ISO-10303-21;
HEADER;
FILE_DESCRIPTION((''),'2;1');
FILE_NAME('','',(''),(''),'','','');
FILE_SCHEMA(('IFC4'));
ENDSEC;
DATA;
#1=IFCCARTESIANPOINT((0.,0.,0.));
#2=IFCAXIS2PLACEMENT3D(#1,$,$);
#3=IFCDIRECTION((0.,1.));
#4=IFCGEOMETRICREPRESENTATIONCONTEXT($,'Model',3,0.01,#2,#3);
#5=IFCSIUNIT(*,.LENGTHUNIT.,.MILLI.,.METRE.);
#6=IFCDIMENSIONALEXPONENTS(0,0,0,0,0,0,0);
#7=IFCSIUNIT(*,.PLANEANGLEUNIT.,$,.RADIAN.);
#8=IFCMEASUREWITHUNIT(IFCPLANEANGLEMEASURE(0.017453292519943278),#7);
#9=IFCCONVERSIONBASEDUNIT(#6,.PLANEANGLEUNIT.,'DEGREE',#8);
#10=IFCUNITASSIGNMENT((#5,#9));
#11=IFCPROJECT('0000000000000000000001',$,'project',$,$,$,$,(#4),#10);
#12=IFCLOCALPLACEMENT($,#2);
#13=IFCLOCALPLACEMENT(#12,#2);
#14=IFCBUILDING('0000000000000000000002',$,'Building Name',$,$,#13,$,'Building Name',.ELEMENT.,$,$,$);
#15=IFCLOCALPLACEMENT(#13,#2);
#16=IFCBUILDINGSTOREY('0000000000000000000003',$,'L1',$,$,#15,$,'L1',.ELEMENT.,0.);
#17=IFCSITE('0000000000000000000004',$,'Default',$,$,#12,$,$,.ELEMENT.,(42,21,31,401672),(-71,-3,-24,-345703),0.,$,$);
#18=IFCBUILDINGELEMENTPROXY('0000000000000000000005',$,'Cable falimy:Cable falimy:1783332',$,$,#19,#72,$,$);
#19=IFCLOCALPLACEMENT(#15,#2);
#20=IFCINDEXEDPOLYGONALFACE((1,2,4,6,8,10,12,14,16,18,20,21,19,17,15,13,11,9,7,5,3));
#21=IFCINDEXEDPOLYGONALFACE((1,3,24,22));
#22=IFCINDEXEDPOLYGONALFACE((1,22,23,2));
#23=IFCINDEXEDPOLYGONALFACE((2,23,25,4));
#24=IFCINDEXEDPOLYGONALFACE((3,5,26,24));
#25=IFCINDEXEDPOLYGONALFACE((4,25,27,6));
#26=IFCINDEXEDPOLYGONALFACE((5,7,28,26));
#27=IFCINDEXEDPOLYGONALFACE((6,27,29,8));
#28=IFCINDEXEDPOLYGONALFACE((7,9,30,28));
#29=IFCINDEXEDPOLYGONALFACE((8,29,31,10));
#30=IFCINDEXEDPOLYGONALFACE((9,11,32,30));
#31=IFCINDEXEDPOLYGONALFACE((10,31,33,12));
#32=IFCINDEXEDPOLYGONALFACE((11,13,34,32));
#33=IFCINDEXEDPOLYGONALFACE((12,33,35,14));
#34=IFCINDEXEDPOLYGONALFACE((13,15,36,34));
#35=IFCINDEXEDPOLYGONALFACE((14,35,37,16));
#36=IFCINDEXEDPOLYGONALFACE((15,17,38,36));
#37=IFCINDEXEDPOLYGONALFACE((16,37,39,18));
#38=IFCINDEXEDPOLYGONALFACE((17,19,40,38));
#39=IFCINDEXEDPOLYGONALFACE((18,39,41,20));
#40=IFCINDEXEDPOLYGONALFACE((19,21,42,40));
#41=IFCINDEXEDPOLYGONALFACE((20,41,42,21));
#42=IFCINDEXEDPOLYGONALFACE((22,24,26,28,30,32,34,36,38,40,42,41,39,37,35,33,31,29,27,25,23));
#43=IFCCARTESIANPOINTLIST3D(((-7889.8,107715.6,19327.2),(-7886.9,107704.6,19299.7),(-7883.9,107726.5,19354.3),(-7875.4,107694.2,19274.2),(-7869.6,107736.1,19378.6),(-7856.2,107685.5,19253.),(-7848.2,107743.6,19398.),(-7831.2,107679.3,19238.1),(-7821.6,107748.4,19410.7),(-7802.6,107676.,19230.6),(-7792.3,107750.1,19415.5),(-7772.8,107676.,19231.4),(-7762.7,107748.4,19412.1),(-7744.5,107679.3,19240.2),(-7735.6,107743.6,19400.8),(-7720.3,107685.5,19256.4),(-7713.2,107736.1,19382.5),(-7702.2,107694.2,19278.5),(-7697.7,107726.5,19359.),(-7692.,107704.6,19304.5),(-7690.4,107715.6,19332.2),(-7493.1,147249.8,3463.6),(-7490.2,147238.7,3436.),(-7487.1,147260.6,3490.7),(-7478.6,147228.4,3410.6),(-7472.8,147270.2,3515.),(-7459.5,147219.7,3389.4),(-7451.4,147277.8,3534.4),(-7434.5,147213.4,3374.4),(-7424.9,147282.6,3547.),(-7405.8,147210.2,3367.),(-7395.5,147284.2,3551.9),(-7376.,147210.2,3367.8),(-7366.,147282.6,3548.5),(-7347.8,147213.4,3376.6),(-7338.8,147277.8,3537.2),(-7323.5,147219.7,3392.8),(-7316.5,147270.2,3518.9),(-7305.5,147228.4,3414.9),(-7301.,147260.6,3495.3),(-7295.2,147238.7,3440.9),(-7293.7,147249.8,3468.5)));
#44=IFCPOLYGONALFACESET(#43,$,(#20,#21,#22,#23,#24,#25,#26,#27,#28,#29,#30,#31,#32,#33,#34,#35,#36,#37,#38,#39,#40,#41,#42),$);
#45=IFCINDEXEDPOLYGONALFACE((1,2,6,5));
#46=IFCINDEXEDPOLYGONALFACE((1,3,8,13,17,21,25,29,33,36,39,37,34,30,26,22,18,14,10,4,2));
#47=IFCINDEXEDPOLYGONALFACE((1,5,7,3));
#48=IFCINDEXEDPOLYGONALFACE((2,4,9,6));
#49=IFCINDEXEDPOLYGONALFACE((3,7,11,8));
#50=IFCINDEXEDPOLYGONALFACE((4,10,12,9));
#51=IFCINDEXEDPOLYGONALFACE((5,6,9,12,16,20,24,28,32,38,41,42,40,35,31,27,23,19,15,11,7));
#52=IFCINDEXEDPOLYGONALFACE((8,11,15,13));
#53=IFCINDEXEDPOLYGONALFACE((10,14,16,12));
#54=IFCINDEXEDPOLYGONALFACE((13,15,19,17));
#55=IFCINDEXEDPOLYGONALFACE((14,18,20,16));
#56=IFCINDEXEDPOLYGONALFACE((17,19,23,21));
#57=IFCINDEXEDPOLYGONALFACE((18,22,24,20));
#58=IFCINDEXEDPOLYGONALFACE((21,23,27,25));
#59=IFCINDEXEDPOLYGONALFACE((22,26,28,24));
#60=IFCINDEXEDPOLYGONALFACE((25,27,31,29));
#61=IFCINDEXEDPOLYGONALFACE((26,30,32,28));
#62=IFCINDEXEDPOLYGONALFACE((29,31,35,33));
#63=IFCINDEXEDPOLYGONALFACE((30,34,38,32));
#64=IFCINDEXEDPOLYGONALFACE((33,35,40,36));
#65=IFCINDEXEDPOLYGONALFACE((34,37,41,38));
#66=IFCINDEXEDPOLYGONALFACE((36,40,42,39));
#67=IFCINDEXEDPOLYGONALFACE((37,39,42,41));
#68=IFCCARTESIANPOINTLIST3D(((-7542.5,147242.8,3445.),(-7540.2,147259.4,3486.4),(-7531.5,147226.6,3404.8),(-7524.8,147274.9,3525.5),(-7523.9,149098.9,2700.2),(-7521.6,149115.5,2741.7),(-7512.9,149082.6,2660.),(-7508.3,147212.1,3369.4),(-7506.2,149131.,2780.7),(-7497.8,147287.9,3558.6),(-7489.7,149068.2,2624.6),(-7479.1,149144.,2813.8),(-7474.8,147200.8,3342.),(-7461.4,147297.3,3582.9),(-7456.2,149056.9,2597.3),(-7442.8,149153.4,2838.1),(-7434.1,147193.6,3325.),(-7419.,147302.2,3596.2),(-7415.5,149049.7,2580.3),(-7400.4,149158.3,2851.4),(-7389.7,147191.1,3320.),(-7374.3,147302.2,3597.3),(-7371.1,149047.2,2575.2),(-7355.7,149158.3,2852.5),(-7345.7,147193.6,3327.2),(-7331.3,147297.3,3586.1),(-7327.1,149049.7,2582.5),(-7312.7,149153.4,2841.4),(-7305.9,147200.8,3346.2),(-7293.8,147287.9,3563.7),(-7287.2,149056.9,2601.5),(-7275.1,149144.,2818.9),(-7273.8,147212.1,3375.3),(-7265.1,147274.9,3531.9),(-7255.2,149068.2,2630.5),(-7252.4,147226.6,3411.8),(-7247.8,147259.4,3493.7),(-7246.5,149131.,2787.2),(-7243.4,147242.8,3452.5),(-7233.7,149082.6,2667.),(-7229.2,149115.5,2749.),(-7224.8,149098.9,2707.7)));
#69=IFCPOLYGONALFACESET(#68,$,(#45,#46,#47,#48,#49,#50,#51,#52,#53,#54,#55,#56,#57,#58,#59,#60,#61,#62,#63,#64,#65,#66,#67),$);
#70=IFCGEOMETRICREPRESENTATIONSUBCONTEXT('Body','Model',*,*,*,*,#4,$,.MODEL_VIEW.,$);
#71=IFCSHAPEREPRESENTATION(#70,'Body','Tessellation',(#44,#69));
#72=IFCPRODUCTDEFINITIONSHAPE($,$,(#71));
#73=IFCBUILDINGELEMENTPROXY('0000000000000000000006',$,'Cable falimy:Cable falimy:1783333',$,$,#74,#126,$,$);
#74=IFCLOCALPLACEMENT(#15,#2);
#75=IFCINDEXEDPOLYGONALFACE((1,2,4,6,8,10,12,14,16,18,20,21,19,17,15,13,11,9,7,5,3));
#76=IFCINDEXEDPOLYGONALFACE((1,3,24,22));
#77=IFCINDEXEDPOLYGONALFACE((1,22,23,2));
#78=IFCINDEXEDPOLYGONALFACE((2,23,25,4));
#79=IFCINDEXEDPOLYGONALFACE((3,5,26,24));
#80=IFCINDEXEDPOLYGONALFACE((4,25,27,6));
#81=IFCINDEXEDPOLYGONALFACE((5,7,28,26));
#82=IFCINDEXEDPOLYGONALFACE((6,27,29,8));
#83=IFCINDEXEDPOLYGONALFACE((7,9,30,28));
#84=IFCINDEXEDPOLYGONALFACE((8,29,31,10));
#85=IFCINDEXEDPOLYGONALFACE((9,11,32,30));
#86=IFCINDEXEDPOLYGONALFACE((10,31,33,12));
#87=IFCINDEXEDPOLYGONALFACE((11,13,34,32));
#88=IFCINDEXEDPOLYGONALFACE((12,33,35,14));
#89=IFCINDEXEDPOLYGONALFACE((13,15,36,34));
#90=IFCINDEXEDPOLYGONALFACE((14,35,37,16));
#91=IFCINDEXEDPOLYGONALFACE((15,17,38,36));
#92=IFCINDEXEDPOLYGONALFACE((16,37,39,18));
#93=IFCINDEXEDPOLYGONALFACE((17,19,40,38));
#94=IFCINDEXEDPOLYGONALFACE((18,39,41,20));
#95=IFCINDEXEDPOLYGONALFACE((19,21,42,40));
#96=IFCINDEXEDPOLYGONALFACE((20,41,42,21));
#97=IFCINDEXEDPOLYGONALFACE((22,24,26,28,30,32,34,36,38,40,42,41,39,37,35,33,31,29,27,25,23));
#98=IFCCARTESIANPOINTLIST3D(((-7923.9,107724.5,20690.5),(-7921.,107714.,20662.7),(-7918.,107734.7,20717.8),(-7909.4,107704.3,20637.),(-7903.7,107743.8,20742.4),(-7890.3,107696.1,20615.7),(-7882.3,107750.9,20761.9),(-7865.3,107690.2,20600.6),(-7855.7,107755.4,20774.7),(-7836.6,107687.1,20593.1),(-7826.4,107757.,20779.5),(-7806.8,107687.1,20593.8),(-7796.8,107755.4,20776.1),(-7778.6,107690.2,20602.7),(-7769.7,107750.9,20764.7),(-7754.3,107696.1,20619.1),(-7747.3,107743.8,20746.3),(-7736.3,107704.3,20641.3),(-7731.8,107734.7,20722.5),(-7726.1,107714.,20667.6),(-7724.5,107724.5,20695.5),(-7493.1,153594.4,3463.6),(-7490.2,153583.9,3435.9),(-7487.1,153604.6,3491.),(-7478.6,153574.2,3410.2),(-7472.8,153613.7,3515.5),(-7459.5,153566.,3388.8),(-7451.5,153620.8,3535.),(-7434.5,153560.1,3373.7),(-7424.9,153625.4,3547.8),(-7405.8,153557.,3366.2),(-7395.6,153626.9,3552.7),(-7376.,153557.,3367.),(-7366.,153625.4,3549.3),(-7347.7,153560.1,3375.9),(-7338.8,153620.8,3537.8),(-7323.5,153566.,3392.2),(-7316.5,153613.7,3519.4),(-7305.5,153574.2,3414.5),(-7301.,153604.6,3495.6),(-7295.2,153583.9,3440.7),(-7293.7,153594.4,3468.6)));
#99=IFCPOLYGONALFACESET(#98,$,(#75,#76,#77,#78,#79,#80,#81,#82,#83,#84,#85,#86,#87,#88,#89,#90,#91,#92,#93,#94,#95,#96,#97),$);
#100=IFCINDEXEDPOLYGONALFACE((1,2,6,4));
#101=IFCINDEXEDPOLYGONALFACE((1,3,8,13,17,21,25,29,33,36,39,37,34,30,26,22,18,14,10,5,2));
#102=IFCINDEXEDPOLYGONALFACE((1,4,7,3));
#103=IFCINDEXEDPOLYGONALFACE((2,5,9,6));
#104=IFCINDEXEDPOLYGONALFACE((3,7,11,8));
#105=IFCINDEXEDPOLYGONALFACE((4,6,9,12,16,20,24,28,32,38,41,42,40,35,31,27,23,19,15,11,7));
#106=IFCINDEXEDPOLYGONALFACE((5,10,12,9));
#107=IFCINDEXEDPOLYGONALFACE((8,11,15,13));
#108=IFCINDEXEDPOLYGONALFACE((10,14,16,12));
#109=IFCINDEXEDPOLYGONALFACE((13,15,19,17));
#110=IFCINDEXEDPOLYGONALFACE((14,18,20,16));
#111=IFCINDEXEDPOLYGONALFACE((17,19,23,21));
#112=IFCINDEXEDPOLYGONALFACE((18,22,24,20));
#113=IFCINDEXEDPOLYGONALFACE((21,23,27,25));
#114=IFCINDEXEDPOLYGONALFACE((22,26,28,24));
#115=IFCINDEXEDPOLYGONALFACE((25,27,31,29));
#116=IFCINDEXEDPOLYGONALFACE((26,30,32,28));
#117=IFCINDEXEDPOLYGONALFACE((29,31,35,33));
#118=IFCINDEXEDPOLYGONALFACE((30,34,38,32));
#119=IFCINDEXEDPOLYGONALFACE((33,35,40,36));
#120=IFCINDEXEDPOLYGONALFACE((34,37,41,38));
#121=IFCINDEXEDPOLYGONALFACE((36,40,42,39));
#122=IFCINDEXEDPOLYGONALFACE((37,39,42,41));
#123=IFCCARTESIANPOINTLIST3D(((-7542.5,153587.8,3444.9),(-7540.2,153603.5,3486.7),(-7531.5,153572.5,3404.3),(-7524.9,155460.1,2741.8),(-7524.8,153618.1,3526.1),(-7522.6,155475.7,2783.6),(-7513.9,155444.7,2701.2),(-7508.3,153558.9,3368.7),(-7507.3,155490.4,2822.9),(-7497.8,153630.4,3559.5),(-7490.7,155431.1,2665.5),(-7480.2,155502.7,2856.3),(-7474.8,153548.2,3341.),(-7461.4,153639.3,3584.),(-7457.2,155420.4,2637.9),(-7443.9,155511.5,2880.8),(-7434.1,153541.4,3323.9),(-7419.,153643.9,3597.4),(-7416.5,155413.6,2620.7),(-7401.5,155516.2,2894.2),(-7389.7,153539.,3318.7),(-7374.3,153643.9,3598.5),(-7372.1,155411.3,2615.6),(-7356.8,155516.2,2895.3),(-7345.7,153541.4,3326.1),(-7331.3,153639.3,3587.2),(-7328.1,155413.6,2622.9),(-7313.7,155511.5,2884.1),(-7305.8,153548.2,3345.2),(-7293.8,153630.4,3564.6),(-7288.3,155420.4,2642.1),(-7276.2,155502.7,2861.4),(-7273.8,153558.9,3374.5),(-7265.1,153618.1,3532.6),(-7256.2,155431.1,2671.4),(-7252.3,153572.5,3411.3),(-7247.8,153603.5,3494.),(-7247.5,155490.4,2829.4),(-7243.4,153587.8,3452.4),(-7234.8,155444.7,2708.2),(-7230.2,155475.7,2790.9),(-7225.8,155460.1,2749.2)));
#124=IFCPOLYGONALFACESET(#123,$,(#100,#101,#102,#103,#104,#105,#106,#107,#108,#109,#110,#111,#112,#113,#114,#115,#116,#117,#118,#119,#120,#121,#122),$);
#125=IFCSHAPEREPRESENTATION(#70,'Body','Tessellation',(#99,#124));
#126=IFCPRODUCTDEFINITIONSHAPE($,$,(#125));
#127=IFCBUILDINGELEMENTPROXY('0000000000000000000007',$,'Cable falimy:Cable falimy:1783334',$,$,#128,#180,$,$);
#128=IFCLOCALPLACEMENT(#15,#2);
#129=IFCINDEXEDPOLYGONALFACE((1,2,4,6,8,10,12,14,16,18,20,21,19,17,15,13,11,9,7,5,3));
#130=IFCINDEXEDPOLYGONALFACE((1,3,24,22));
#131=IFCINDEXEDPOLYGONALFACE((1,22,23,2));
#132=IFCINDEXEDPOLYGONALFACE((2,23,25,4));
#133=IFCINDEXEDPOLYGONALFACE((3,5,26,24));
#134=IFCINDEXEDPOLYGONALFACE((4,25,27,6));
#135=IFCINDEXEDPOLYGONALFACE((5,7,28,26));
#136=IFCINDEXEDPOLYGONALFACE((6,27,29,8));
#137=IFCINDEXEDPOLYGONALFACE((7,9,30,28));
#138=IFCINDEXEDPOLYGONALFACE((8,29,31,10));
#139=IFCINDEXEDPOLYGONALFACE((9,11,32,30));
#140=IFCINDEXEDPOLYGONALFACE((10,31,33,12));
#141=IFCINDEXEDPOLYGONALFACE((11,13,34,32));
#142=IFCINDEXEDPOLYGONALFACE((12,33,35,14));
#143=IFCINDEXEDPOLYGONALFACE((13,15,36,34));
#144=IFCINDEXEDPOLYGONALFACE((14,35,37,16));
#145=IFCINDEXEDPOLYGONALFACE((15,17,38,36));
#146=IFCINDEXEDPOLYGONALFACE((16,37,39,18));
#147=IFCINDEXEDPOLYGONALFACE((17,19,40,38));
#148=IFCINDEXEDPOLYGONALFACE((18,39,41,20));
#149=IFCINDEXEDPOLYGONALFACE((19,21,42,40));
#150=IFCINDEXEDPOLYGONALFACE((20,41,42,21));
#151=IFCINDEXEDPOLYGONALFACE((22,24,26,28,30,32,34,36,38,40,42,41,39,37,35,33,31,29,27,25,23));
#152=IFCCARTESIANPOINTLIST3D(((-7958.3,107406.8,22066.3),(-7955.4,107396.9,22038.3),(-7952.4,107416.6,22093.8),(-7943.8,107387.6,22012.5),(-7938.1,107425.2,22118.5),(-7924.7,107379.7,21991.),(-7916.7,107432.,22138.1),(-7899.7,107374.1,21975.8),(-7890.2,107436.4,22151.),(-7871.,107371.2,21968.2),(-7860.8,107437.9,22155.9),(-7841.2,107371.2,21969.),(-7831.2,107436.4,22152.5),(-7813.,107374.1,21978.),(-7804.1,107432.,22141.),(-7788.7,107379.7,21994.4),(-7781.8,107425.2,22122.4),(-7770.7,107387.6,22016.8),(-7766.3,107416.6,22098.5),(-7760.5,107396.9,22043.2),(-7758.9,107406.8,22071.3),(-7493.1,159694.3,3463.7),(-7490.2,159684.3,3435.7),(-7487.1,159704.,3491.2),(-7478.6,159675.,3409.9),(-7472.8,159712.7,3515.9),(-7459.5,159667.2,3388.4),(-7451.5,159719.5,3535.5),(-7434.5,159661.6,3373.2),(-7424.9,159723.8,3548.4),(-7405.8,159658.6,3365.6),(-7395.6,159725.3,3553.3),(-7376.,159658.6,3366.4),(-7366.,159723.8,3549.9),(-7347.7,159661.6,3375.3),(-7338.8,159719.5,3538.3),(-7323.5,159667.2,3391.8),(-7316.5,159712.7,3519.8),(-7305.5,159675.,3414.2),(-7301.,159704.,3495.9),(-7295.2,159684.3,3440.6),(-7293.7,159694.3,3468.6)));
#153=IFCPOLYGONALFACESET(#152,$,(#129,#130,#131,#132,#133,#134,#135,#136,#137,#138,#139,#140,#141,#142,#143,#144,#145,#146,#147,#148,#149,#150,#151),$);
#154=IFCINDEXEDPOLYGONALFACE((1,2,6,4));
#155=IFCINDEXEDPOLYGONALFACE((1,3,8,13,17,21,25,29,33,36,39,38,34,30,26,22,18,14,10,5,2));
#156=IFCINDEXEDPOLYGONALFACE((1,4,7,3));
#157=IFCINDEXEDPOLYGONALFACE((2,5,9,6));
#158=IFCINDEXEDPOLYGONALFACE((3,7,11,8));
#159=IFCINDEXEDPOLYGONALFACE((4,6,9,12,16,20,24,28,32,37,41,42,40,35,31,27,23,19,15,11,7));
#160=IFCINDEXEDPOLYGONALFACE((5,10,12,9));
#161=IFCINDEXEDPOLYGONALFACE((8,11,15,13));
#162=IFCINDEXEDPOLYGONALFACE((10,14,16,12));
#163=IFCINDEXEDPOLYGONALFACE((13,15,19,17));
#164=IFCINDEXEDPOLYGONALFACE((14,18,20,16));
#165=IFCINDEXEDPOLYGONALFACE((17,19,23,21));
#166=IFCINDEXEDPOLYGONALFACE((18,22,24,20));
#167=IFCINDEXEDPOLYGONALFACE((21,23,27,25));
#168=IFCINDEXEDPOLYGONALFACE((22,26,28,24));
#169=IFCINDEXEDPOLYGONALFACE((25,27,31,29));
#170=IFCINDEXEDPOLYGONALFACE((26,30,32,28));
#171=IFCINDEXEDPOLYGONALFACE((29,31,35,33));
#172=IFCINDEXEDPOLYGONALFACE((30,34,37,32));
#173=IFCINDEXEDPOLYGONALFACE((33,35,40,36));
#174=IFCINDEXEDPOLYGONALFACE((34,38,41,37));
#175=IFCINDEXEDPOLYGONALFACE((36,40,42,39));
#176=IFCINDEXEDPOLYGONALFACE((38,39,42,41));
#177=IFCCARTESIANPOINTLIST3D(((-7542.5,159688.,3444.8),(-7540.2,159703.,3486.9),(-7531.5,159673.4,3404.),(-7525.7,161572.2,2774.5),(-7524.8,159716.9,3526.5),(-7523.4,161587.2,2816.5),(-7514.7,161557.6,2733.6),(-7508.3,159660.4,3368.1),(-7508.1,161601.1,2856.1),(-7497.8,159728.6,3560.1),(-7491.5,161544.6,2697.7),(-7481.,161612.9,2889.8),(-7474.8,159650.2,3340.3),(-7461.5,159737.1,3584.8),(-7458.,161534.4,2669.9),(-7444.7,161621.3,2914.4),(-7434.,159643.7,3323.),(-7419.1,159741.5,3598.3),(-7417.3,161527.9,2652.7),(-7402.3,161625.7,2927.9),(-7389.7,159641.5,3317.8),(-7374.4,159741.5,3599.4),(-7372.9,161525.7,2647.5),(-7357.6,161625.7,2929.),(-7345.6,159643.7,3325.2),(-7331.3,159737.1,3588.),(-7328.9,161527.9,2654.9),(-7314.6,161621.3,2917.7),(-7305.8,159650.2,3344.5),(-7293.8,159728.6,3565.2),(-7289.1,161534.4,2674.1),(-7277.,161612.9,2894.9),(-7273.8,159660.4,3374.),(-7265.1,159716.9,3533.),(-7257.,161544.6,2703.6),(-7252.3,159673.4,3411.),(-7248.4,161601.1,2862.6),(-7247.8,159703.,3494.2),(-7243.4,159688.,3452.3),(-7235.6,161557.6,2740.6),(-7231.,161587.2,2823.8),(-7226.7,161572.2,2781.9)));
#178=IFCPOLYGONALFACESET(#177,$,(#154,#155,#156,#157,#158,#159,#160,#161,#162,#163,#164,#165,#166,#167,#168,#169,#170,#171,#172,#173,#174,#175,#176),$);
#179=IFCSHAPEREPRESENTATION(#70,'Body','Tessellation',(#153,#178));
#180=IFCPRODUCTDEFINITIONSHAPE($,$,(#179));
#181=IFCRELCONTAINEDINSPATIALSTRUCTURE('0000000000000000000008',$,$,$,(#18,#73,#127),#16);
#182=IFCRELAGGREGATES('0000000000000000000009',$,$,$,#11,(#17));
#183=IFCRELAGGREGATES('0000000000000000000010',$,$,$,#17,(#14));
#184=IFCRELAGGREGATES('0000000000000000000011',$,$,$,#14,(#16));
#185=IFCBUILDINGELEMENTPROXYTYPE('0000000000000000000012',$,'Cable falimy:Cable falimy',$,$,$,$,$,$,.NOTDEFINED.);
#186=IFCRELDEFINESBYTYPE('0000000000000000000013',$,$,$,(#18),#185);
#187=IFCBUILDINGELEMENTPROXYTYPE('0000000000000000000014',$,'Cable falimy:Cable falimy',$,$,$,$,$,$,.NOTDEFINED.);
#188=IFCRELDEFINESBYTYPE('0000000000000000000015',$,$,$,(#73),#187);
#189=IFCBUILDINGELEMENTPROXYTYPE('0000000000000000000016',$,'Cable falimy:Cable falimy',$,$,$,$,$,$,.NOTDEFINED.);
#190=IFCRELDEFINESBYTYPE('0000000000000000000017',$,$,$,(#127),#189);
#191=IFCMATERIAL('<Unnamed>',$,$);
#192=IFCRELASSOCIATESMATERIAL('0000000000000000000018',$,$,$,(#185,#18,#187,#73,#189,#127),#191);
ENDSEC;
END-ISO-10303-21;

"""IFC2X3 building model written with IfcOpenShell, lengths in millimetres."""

from ifc_helpers import new_model, entity, si_unit, converted_unit, direction, frame, frame_2d, origin, place, context, subcontext, project, spatial, circle, extrude, source, transform, mapped, material, type_object, type_shapes, element, save


model = new_model("IFC2X3")

# Units and contexts
model_context = context("Model", 3, precision=0.01, world=origin(), true_north=direction((0.0, 1.0)))
body_context = subcontext(model_context, "Body", "Model", "MODEL_VIEW")
ifc_project = project(units=[si_unit("LENGTHUNIT", "METRE", prefix="MILLI"), converted_unit("PLANEANGLEUNIT", "DEGREE", entity("IfcPlaneAngleMeasure", 0.017453292519943278), si_unit("PLANEANGLEUNIT", "RADIAN"), dimensions=[0, 0, 0, 0, 0, 0, 0])], contexts=[model_context])

# Site, building, storey
site_placement = place(None, origin())
site = spatial("IfcSite", under=ifc_project, at=site_placement, Name="Default", CompositionType="ELEMENT", RefLatitude=(42, 21, 31, 401672), RefLongitude=(-71, -3, -24, -345703), RefElevation=0.0)
building_placement = place(site_placement, origin())
building = spatial("IfcBuilding", under=site, at=building_placement, Name="Building Name", LongName="Building Name", CompositionType="ELEMENT")
storey_placement = place(building_placement, origin())
storey = spatial("IfcBuildingStorey", under=building, at=storey_placement, Name="L1", LongName="L1", CompositionType="ELEMENT", Elevation=0.0)

# Shared definitions
ifc_material = material(Name="<Unnamed>")

# Building element proxies
building_element_proxy_type_1 = type_object("IfcBuildingElementProxyType", Name="Cable falimy:Cable falimy", PredefinedType="NOTDEFINED", material=ifc_material)
shared_shape_1 = source(origin(), body_context, "Body", "SweptSolid", [
    extrude(circle(Radius=100.0, at=frame_2d((0.0, 0.0), x_axis=(1.0, 0.0))), frame((0.0, 0.0, 0.0), z_axis=(0.928031, 0.0, 0.372502), x_axis=(-0.372502, 0.0, 0.928031)), (0.0, 0.0, 1.0), 42600.0),
    extrude(circle(Radius=150.0, at=frame_2d((0.0, 0.0), x_axis=(1.0, 0.0))), frame((-1856.1, 0.0, -745.0), z_axis=(0.928031, 0.0, 0.372502), x_axis=(0.372502, 0.0, -0.928031)), (0.0, 0.0, 1.0), 2000.0),
])
type_shapes(building_element_proxy_type_1, [shared_shape_1])
proxy_1_placement = place(storey_placement, frame((-7393.2, 147247.0, 3459.1), z_axis=(-0.025001, 0.0, 0.999687), x_axis=(0.0, -1.0, 0.0)))
element("IfcBuildingElementProxy", 1, at=proxy_1_placement, inside=storey, type_object=building_element_proxy_type_1, material=ifc_material, Name="Cable falimy:Cable falimy:1783332", context=body_context, shape_type="MappedRepresentation", body=[
    mapped(shared_shape_1, transform((0.0, 0.0, 0.0), scale=1.0)),
])
building_element_proxy_type_2 = type_object("IfcBuildingElementProxyType", Name="Cable falimy:Cable falimy", PredefinedType="NOTDEFINED", material=ifc_material)
shared_shape_2 = source(origin(), body_context, "Body", "SweptSolid", [
    extrude(circle(Radius=100.0, at=frame_2d((0.0, 0.0), x_axis=(1.0, 0.0))), frame((0.0, 0.0, 0.0), z_axis=(0.936121, 0.0, 0.351678), x_axis=(-0.351678, 0.0, 0.936121)), (0.0, 0.0, 1.0), 49000.0),
    extrude(circle(Radius=150.0, at=frame_2d((0.0, 0.0), x_axis=(1.0, 0.0))), frame((-1872.2, 0.0, -703.4), z_axis=(0.936121, 0.0, 0.351678), x_axis=(0.351678, 0.0, -0.936121)), (0.0, 0.0, 1.0), 2000.0),
])
type_shapes(building_element_proxy_type_2, [shared_shape_2])
proxy_2_placement = place(storey_placement, frame((-7393.2, 153591.8, 3459.1), z_axis=(-0.025001, 0.0, 0.999687), x_axis=(0.0, -1.0, 0.0)))
element("IfcBuildingElementProxy", 2, at=proxy_2_placement, inside=storey, type_object=building_element_proxy_type_2, material=ifc_material, Name="Cable falimy:Cable falimy:1783333", context=body_context, shape_type="MappedRepresentation", body=[
    mapped(shared_shape_2, transform((0.0, 0.0, 0.0), scale=1.0)),
])
building_element_proxy_type_3 = type_object("IfcBuildingElementProxyType", Name="Cable falimy:Cable falimy", PredefinedType="NOTDEFINED", material=ifc_material)
shared_shape_3 = source(origin(), body_context, "Body", "SweptSolid", [
    extrude(circle(Radius=100.0, at=frame_2d((0.0, 0.0), x_axis=(1.0, 0.0))), frame((0.0, 0.0, 0.0), z_axis=(0.942116, 0.0, 0.335287), x_axis=(-0.335287, 0.0, 0.942116)), (0.0, 0.0, 1.0), 55500.0),
    extrude(circle(Radius=150.0, at=frame_2d((0.0, 0.0), x_axis=(1.0, 0.0))), frame((-1884.2, 0.0, -670.6), z_axis=(0.942116, 0.0, 0.335287), x_axis=(0.335287, 0.0, -0.942116)), (0.0, 0.0, 1.0), 2000.0),
])
type_shapes(building_element_proxy_type_3, [shared_shape_3])
proxy_3_placement = place(storey_placement, frame((-7393.2, 159691.8, 3459.1), z_axis=(-0.025001, 0.0, 0.999687), x_axis=(0.0, -1.0, 0.0)))
element("IfcBuildingElementProxy", 3, at=proxy_3_placement, inside=storey, type_object=building_element_proxy_type_3, material=ifc_material, Name="Cable falimy:Cable falimy:1783334", context=body_context, shape_type="MappedRepresentation", body=[
    mapped(shared_shape_3, transform((0.0, 0.0, 0.0), scale=1.0)),
])

save(model, "model.ifc")
